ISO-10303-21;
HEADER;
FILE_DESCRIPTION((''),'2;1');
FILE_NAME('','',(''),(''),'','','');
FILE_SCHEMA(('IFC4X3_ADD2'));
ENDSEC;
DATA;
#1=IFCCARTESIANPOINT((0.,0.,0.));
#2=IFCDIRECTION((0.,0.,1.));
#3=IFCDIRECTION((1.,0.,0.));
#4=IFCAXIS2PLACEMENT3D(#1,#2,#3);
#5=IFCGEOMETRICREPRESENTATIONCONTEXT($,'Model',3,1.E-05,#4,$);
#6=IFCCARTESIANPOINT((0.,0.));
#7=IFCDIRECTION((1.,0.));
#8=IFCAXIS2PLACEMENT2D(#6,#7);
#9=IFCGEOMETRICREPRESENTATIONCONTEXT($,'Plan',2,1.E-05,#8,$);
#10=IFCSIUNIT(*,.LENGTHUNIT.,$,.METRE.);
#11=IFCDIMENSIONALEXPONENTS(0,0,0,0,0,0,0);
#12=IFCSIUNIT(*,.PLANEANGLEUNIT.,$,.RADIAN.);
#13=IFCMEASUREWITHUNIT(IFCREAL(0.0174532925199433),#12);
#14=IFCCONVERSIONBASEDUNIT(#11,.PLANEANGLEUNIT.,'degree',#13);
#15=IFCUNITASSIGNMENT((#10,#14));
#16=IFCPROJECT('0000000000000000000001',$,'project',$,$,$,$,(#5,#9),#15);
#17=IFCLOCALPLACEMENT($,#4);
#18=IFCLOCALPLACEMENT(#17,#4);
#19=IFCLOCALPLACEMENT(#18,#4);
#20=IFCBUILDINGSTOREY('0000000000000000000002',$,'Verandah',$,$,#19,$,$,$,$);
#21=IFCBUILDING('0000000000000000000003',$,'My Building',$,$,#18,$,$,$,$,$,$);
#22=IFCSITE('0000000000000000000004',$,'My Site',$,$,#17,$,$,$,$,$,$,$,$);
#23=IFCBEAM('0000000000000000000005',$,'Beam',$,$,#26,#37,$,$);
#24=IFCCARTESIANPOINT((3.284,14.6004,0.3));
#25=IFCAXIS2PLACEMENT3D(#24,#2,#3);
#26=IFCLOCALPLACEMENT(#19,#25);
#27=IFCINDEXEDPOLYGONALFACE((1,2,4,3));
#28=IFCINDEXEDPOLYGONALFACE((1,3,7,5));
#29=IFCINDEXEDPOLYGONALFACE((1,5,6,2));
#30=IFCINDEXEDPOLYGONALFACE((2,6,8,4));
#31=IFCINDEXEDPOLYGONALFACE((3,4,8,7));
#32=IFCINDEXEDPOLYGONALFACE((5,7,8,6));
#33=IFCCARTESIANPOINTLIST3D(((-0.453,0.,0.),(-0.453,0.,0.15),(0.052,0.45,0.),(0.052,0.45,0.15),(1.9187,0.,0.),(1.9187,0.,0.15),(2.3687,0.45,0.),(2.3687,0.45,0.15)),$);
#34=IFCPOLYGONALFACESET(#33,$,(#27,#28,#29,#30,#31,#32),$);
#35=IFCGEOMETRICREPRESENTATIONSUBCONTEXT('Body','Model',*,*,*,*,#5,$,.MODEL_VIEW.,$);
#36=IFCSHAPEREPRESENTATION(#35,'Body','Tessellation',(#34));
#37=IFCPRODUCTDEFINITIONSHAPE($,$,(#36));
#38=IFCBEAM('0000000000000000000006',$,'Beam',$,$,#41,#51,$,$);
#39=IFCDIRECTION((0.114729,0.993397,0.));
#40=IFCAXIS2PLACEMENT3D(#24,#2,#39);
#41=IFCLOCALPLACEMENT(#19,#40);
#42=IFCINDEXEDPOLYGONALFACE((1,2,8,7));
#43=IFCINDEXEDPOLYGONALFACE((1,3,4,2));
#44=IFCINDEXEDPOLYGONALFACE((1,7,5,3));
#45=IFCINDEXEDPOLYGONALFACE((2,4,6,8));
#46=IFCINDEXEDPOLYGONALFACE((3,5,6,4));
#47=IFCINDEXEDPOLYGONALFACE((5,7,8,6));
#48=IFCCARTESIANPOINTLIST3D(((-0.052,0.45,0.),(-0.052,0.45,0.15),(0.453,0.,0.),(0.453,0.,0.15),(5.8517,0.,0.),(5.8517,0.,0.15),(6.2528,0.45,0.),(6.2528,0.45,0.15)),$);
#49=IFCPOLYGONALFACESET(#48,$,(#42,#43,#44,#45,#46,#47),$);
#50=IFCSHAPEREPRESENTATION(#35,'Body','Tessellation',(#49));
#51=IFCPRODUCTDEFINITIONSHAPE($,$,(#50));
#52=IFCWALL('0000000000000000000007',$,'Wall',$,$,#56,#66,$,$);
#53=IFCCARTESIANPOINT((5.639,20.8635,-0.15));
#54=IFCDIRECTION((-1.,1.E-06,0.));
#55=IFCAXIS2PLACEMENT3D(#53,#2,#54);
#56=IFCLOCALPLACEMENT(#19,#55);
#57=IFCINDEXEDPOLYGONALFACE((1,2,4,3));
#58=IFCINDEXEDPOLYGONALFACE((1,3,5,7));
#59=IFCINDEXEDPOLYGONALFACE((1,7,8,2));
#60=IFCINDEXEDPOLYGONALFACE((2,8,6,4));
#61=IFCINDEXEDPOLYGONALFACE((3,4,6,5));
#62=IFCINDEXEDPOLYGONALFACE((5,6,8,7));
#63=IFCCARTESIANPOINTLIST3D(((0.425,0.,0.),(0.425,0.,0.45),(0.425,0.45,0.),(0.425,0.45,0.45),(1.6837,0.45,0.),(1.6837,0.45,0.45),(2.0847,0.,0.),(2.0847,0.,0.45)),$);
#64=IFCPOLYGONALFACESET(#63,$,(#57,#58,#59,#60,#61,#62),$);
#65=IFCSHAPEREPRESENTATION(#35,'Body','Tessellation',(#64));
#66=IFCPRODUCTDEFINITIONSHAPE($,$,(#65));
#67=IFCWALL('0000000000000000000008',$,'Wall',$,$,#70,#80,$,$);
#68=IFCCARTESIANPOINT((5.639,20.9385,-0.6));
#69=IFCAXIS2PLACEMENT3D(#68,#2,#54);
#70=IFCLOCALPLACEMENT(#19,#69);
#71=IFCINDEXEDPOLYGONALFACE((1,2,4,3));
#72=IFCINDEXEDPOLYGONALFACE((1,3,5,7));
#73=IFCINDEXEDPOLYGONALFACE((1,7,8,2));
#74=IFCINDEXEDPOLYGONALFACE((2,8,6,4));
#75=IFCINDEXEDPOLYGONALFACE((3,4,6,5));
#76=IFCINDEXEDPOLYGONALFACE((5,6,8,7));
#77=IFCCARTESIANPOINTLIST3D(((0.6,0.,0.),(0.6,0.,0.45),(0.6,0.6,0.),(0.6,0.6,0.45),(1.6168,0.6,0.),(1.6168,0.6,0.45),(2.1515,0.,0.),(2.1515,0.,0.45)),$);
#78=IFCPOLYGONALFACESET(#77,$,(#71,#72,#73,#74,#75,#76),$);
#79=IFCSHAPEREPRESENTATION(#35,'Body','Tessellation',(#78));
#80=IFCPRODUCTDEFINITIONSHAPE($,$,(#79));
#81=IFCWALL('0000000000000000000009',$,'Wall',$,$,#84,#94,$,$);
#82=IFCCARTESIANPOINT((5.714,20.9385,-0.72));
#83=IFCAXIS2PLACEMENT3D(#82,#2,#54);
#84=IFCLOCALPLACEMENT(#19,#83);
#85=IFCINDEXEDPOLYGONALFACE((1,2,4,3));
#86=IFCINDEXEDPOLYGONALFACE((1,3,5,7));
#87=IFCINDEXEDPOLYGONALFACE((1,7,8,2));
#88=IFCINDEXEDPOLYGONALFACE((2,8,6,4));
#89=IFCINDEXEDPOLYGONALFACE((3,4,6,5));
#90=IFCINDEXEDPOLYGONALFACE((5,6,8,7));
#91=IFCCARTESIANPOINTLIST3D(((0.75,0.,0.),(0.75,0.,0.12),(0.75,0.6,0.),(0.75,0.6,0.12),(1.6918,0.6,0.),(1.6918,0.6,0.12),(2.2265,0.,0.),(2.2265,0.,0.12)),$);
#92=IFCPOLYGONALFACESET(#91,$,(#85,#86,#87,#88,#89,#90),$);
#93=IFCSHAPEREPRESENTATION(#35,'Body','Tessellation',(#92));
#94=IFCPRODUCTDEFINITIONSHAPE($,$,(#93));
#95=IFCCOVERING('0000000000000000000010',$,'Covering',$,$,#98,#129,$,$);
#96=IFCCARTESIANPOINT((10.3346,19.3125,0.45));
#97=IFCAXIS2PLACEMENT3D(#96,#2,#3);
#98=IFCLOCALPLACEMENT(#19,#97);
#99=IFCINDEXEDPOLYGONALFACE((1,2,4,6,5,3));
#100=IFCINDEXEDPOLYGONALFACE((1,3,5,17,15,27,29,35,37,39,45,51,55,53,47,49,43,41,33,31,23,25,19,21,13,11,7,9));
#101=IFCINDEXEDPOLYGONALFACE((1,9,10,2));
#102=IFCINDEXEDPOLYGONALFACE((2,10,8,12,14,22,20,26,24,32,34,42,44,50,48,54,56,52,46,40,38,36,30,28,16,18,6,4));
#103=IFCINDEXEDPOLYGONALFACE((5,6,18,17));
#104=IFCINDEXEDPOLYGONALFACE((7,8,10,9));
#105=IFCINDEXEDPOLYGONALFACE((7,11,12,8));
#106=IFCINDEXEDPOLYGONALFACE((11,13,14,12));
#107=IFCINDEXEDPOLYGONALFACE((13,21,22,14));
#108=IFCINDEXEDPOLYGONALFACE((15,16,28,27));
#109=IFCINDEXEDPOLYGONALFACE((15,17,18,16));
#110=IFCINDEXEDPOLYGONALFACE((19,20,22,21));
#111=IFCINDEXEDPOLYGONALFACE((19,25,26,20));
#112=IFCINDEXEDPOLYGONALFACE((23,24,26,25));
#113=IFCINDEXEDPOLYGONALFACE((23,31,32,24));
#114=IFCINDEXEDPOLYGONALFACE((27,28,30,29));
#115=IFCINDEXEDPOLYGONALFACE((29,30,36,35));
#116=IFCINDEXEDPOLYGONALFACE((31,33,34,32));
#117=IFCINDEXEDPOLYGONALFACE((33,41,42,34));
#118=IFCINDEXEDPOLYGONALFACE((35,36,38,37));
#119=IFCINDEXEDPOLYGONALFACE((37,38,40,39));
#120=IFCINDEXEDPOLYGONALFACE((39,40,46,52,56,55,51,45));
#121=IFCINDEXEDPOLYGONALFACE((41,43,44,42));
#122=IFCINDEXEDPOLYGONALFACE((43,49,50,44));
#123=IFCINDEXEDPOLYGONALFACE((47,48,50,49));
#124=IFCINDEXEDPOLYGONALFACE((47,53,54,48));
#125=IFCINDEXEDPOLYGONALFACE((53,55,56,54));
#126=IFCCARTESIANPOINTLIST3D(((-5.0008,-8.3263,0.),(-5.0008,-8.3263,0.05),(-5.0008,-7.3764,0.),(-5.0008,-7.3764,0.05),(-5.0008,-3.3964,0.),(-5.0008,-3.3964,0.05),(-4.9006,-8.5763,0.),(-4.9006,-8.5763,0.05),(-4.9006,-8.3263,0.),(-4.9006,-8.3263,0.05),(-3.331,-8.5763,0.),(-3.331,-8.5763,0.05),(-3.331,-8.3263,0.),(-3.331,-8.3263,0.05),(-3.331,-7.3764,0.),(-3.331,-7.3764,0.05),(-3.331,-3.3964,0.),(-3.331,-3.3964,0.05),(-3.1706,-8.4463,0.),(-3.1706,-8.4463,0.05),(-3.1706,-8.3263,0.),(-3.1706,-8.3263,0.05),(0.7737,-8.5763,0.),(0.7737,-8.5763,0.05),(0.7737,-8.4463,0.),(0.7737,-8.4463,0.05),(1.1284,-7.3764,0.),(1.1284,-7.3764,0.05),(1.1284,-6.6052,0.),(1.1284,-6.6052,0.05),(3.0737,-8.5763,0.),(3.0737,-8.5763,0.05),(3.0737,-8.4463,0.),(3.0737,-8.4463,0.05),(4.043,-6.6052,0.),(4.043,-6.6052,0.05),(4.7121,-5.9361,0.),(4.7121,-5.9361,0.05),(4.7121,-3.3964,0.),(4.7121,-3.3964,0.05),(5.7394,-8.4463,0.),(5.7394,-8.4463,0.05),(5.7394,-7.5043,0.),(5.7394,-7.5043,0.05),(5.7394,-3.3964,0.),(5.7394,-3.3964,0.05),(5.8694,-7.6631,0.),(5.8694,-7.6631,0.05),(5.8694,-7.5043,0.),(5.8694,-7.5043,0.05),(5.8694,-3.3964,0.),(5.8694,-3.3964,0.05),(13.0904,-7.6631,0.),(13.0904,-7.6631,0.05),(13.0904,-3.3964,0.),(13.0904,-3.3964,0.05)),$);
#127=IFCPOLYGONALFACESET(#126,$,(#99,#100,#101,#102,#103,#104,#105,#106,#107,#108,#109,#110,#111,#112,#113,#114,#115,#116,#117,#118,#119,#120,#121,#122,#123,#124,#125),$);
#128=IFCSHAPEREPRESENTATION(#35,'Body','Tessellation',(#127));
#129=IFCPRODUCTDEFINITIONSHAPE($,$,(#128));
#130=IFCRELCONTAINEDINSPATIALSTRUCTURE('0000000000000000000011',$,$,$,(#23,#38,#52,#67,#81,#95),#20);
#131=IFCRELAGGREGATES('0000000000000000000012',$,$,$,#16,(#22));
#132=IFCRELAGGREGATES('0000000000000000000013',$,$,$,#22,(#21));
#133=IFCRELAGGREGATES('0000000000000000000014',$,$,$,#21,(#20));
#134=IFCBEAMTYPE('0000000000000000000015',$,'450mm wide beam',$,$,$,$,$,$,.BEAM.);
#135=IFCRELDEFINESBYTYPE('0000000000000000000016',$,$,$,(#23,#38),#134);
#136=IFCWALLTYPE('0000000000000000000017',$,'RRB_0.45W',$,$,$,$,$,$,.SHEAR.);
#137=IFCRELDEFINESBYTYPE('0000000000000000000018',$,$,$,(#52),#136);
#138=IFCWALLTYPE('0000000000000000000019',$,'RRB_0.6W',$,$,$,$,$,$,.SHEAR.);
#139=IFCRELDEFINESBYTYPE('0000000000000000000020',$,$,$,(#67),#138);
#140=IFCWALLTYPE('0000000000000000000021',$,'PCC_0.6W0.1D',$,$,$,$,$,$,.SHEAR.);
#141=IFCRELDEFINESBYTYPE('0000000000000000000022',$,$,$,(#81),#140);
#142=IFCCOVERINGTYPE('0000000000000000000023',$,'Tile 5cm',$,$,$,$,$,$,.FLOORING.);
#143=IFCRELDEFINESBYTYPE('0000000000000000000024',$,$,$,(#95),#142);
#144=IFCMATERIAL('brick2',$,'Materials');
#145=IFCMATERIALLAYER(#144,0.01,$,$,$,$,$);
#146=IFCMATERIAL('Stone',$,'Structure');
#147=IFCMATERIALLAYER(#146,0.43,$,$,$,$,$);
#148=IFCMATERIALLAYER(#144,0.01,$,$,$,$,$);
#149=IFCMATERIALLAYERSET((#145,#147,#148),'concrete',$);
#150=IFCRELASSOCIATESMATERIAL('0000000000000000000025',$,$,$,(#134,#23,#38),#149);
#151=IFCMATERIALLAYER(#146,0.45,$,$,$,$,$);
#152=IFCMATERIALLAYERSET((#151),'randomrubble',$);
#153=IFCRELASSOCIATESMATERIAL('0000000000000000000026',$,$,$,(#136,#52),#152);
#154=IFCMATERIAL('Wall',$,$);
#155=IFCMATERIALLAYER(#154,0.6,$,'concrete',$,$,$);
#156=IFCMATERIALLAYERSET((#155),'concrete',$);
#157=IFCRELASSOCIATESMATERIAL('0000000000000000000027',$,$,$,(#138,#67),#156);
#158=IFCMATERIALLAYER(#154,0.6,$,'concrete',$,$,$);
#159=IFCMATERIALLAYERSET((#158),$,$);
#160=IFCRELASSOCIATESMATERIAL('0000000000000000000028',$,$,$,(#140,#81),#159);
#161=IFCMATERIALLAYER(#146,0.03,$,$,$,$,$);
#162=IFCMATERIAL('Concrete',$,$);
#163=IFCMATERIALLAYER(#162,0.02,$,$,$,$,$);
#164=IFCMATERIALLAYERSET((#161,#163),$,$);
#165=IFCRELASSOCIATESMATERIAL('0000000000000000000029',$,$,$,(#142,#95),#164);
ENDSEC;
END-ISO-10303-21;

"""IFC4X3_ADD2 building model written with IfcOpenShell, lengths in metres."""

from ifc_helpers import new_model, entity, si_unit, converted_unit, frame, origin_with_axes, origin_2d_with_axis, place, context, subcontext, project, spatial, line, indexed_curve, outline, extrude, material, layer, layer_set, layer_usage, type_object, element, save


model = new_model("IFC4X3_ADD2")

# Units and contexts
model_context = context("Model", 3, precision=1e-05, world=origin_with_axes())
plan_context = context("Plan", 2, precision=1e-05, world=origin_2d_with_axis())
body_context = subcontext(model_context, "Body", "Model", "MODEL_VIEW")
ifc_project = project(units=[si_unit("LENGTHUNIT", "METRE"), converted_unit("PLANEANGLEUNIT", "degree", entity("IfcReal", 0.0174532925199433), si_unit("PLANEANGLEUNIT", "RADIAN"), dimensions=[0, 0, 0, 0, 0, 0, 0])], contexts=[model_context, plan_context])

# Site, building, storey
site_placement = place(None, origin_with_axes())
site = spatial("IfcSite", under=ifc_project, at=site_placement, Name="My Site")
building_placement = place(site_placement, origin_with_axes())
building = spatial("IfcBuilding", under=site, at=building_placement, Name="My Building")
storey_placement = place(building_placement, origin_with_axes())
storey = spatial("IfcBuildingStorey", under=building, at=storey_placement, Name="Verandah")

# Beams
ifc_material_1 = material(Name="brick2", Category="Materials")
ifc_layer_1 = layer(ifc_material_1, 0.01)
ifc_material_2 = material(Name="Stone", Category="Structure")
ifc_layer_2 = layer(ifc_material_2, 0.43)
ifc_layer_3 = layer(ifc_material_1, 0.01)
ifc_layer_set_1 = layer_set([ifc_layer_1, ifc_layer_2, ifc_layer_3], Name="concrete")
beam_type = type_object("IfcBeamType", Name="450mm wide beam", PredefinedType="BEAM", material=ifc_layer_set_1)
ifc_layer_usage_1 = layer_usage(ifc_layer_set_1, "AXIS2", "POSITIVE", 0.0)
beam_1_placement = place(storey_placement, frame((3.284, 14.6004, 0.3), z_axis=(0.0, 0.0, 1.0), x_axis=(1.0, 0.0, 0.0)))
element("IfcBeam", 1, at=beam_1_placement, inside=storey, type_object=beam_type, material=ifc_layer_usage_1, Name="Beam", context=body_context, shape_type="SweptSolid", body=[
    extrude(outline(indexed_curve([(-0.453, 0.0), (0.052, 0.45), (2.3687, 0.45), (1.9187, 0.0)], segments=[line(1, 2, 3, 4, 1)])), origin_with_axes(), (0.0, 0.0, 1.0), 0.15),
])
ifc_layer_usage_2 = layer_usage(ifc_layer_set_1, "AXIS2", "POSITIVE", 0.0)
beam_2_placement = place(storey_placement, frame((3.284, 14.6004, 0.3), z_axis=(0.0, 0.0, 1.0), x_axis=(0.114729, 0.993397, 0.0)))
element("IfcBeam", 2, at=beam_2_placement, inside=storey, type_object=beam_type, material=ifc_layer_usage_2, Name="Beam", context=body_context, shape_type="SweptSolid", body=[
    extrude(outline(indexed_curve([(0.453, 0.0), (-0.052, 0.45), (6.2528, 0.45), (5.8517, 0.0)], segments=[line(1, 2, 3, 4, 1)])), origin_with_axes(), (0.0, 0.0, 1.0), 0.15),
])

# Walls
ifc_layer_4 = layer(ifc_material_2, 0.45)
ifc_layer_set_2 = layer_set([ifc_layer_4], Name="randomrubble")
wall_type_1 = type_object("IfcWallType", Name="RRB_0.45W", PredefinedType="SHEAR", material=ifc_layer_set_2)
ifc_layer_usage_3 = layer_usage(ifc_layer_set_2, "AXIS2", "POSITIVE", 0.0)
wall_1_placement = place(storey_placement, frame((5.639, 20.8635, -0.15), z_axis=(0.0, 0.0, 1.0), x_axis=(-1.0, 0.000001, 0.0)))
element("IfcWall", 3, at=wall_1_placement, inside=storey, type_object=wall_type_1, material=ifc_layer_usage_3, Name="Wall", context=body_context, shape_type="SweptSolid", body=[
    extrude(outline(indexed_curve([(0.425, 0.0), (0.425, 0.45), (1.6837, 0.45), (2.0847, 0.0)], segments=[line(1, 2, 3, 4, 1)])), origin_with_axes(), (0.0, 0.0, 1.0), 0.45),
])
ifc_material_3 = material(Name="Wall")
ifc_layer_5 = layer(ifc_material_3, 0.6, Name="concrete")
ifc_layer_set_3 = layer_set([ifc_layer_5], Name="concrete")
wall_type_2 = type_object("IfcWallType", Name="RRB_0.6W", PredefinedType="SHEAR", material=ifc_layer_set_3)
ifc_layer_usage_4 = layer_usage(ifc_layer_set_3, "AXIS2", "POSITIVE", 0.0)
wall_2_placement = place(storey_placement, frame((5.639, 20.9385, -0.6), z_axis=(0.0, 0.0, 1.0), x_axis=(-1.0, 0.000001, 0.0)))
element("IfcWall", 4, at=wall_2_placement, inside=storey, type_object=wall_type_2, material=ifc_layer_usage_4, Name="Wall", context=body_context, shape_type="SweptSolid", body=[
    extrude(outline(indexed_curve([(0.6, 0.0), (0.6, 0.6), (1.6168, 0.6), (2.1515, 0.0)], segments=[line(1, 2, 3, 4, 1)])), origin_with_axes(), (0.0, 0.0, 1.0), 0.45),
])
ifc_layer_6 = layer(ifc_material_3, 0.6, Name="concrete")
ifc_layer_set_4 = layer_set([ifc_layer_6])
wall_type_3 = type_object("IfcWallType", Name="PCC_0.6W0.1D", PredefinedType="SHEAR", material=ifc_layer_set_4)
ifc_layer_usage_5 = layer_usage(ifc_layer_set_4, "AXIS2", "POSITIVE", 0.0)
wall_3_placement = place(storey_placement, frame((5.714, 20.9385, -0.72), z_axis=(0.0, 0.0, 1.0), x_axis=(-1.0, 0.000001, 0.0)))
element("IfcWall", 5, at=wall_3_placement, inside=storey, type_object=wall_type_3, material=ifc_layer_usage_5, Name="Wall", context=body_context, shape_type="SweptSolid", body=[
    extrude(outline(indexed_curve([(0.75, 0.0), (0.75, 0.6), (1.6918, 0.6), (2.2265, 0.0)], segments=[line(1, 2, 3, 4, 1)])), origin_with_axes(), (0.0, 0.0, 1.0), 0.12),
])

# Covering
ifc_layer_7 = layer(ifc_material_2, 0.03)
ifc_material_4 = material(Name="Concrete")
ifc_layer_8 = layer(ifc_material_4, 0.02)
ifc_layer_set_5 = layer_set([ifc_layer_7, ifc_layer_8])
ifc_layer_usage_6 = layer_usage(ifc_layer_set_5, "AXIS3", "POSITIVE", 0.0)
covering_type = type_object("IfcCoveringType", Name="Tile 5cm", PredefinedType="FLOORING", material=ifc_layer_set_5)
covering_placement = place(storey_placement, frame((10.3346, 19.3125, 0.45), z_axis=(0.0, 0.0, 1.0), x_axis=(1.0, 0.0, 0.0)))
element("IfcCovering", 6, at=covering_placement, inside=storey, type_object=covering_type, material=ifc_layer_usage_6, Name="Covering", context=body_context, shape_type="SweptSolid", body=[
    extrude(outline(indexed_curve([(5.8694, -7.5043), (5.7394, -7.5043), (5.7394, -8.4463), (3.0737, -8.4463), (3.0737, -8.5763), (0.7737, -8.5763), (0.7737, -8.4463), (-3.1706, -8.4463), (-3.1706, -8.3263), (-3.331, -8.3263), (-3.331, -8.5763), (-4.9006, -8.5763), (-4.9006, -8.3263), (-5.0008, -8.3263), (-5.0008, -7.3764), (-5.0008, -3.3964), (-3.331, -3.3964), (-3.331, -7.3764), (1.1284, -7.3764), (1.1284, -6.6052), (4.043, -6.6052), (4.7121, -5.9361), (4.7121, -3.3964), (5.7394, -3.3964), (5.8694, -3.3964), (13.0904, -3.3964), (13.0904, -7.6631), (5.8694, -7.6631), (5.8694, -7.5043)])), None, (0.0, 0.0, 1.0), 0.05),
])

save(model, "model.ifc")
